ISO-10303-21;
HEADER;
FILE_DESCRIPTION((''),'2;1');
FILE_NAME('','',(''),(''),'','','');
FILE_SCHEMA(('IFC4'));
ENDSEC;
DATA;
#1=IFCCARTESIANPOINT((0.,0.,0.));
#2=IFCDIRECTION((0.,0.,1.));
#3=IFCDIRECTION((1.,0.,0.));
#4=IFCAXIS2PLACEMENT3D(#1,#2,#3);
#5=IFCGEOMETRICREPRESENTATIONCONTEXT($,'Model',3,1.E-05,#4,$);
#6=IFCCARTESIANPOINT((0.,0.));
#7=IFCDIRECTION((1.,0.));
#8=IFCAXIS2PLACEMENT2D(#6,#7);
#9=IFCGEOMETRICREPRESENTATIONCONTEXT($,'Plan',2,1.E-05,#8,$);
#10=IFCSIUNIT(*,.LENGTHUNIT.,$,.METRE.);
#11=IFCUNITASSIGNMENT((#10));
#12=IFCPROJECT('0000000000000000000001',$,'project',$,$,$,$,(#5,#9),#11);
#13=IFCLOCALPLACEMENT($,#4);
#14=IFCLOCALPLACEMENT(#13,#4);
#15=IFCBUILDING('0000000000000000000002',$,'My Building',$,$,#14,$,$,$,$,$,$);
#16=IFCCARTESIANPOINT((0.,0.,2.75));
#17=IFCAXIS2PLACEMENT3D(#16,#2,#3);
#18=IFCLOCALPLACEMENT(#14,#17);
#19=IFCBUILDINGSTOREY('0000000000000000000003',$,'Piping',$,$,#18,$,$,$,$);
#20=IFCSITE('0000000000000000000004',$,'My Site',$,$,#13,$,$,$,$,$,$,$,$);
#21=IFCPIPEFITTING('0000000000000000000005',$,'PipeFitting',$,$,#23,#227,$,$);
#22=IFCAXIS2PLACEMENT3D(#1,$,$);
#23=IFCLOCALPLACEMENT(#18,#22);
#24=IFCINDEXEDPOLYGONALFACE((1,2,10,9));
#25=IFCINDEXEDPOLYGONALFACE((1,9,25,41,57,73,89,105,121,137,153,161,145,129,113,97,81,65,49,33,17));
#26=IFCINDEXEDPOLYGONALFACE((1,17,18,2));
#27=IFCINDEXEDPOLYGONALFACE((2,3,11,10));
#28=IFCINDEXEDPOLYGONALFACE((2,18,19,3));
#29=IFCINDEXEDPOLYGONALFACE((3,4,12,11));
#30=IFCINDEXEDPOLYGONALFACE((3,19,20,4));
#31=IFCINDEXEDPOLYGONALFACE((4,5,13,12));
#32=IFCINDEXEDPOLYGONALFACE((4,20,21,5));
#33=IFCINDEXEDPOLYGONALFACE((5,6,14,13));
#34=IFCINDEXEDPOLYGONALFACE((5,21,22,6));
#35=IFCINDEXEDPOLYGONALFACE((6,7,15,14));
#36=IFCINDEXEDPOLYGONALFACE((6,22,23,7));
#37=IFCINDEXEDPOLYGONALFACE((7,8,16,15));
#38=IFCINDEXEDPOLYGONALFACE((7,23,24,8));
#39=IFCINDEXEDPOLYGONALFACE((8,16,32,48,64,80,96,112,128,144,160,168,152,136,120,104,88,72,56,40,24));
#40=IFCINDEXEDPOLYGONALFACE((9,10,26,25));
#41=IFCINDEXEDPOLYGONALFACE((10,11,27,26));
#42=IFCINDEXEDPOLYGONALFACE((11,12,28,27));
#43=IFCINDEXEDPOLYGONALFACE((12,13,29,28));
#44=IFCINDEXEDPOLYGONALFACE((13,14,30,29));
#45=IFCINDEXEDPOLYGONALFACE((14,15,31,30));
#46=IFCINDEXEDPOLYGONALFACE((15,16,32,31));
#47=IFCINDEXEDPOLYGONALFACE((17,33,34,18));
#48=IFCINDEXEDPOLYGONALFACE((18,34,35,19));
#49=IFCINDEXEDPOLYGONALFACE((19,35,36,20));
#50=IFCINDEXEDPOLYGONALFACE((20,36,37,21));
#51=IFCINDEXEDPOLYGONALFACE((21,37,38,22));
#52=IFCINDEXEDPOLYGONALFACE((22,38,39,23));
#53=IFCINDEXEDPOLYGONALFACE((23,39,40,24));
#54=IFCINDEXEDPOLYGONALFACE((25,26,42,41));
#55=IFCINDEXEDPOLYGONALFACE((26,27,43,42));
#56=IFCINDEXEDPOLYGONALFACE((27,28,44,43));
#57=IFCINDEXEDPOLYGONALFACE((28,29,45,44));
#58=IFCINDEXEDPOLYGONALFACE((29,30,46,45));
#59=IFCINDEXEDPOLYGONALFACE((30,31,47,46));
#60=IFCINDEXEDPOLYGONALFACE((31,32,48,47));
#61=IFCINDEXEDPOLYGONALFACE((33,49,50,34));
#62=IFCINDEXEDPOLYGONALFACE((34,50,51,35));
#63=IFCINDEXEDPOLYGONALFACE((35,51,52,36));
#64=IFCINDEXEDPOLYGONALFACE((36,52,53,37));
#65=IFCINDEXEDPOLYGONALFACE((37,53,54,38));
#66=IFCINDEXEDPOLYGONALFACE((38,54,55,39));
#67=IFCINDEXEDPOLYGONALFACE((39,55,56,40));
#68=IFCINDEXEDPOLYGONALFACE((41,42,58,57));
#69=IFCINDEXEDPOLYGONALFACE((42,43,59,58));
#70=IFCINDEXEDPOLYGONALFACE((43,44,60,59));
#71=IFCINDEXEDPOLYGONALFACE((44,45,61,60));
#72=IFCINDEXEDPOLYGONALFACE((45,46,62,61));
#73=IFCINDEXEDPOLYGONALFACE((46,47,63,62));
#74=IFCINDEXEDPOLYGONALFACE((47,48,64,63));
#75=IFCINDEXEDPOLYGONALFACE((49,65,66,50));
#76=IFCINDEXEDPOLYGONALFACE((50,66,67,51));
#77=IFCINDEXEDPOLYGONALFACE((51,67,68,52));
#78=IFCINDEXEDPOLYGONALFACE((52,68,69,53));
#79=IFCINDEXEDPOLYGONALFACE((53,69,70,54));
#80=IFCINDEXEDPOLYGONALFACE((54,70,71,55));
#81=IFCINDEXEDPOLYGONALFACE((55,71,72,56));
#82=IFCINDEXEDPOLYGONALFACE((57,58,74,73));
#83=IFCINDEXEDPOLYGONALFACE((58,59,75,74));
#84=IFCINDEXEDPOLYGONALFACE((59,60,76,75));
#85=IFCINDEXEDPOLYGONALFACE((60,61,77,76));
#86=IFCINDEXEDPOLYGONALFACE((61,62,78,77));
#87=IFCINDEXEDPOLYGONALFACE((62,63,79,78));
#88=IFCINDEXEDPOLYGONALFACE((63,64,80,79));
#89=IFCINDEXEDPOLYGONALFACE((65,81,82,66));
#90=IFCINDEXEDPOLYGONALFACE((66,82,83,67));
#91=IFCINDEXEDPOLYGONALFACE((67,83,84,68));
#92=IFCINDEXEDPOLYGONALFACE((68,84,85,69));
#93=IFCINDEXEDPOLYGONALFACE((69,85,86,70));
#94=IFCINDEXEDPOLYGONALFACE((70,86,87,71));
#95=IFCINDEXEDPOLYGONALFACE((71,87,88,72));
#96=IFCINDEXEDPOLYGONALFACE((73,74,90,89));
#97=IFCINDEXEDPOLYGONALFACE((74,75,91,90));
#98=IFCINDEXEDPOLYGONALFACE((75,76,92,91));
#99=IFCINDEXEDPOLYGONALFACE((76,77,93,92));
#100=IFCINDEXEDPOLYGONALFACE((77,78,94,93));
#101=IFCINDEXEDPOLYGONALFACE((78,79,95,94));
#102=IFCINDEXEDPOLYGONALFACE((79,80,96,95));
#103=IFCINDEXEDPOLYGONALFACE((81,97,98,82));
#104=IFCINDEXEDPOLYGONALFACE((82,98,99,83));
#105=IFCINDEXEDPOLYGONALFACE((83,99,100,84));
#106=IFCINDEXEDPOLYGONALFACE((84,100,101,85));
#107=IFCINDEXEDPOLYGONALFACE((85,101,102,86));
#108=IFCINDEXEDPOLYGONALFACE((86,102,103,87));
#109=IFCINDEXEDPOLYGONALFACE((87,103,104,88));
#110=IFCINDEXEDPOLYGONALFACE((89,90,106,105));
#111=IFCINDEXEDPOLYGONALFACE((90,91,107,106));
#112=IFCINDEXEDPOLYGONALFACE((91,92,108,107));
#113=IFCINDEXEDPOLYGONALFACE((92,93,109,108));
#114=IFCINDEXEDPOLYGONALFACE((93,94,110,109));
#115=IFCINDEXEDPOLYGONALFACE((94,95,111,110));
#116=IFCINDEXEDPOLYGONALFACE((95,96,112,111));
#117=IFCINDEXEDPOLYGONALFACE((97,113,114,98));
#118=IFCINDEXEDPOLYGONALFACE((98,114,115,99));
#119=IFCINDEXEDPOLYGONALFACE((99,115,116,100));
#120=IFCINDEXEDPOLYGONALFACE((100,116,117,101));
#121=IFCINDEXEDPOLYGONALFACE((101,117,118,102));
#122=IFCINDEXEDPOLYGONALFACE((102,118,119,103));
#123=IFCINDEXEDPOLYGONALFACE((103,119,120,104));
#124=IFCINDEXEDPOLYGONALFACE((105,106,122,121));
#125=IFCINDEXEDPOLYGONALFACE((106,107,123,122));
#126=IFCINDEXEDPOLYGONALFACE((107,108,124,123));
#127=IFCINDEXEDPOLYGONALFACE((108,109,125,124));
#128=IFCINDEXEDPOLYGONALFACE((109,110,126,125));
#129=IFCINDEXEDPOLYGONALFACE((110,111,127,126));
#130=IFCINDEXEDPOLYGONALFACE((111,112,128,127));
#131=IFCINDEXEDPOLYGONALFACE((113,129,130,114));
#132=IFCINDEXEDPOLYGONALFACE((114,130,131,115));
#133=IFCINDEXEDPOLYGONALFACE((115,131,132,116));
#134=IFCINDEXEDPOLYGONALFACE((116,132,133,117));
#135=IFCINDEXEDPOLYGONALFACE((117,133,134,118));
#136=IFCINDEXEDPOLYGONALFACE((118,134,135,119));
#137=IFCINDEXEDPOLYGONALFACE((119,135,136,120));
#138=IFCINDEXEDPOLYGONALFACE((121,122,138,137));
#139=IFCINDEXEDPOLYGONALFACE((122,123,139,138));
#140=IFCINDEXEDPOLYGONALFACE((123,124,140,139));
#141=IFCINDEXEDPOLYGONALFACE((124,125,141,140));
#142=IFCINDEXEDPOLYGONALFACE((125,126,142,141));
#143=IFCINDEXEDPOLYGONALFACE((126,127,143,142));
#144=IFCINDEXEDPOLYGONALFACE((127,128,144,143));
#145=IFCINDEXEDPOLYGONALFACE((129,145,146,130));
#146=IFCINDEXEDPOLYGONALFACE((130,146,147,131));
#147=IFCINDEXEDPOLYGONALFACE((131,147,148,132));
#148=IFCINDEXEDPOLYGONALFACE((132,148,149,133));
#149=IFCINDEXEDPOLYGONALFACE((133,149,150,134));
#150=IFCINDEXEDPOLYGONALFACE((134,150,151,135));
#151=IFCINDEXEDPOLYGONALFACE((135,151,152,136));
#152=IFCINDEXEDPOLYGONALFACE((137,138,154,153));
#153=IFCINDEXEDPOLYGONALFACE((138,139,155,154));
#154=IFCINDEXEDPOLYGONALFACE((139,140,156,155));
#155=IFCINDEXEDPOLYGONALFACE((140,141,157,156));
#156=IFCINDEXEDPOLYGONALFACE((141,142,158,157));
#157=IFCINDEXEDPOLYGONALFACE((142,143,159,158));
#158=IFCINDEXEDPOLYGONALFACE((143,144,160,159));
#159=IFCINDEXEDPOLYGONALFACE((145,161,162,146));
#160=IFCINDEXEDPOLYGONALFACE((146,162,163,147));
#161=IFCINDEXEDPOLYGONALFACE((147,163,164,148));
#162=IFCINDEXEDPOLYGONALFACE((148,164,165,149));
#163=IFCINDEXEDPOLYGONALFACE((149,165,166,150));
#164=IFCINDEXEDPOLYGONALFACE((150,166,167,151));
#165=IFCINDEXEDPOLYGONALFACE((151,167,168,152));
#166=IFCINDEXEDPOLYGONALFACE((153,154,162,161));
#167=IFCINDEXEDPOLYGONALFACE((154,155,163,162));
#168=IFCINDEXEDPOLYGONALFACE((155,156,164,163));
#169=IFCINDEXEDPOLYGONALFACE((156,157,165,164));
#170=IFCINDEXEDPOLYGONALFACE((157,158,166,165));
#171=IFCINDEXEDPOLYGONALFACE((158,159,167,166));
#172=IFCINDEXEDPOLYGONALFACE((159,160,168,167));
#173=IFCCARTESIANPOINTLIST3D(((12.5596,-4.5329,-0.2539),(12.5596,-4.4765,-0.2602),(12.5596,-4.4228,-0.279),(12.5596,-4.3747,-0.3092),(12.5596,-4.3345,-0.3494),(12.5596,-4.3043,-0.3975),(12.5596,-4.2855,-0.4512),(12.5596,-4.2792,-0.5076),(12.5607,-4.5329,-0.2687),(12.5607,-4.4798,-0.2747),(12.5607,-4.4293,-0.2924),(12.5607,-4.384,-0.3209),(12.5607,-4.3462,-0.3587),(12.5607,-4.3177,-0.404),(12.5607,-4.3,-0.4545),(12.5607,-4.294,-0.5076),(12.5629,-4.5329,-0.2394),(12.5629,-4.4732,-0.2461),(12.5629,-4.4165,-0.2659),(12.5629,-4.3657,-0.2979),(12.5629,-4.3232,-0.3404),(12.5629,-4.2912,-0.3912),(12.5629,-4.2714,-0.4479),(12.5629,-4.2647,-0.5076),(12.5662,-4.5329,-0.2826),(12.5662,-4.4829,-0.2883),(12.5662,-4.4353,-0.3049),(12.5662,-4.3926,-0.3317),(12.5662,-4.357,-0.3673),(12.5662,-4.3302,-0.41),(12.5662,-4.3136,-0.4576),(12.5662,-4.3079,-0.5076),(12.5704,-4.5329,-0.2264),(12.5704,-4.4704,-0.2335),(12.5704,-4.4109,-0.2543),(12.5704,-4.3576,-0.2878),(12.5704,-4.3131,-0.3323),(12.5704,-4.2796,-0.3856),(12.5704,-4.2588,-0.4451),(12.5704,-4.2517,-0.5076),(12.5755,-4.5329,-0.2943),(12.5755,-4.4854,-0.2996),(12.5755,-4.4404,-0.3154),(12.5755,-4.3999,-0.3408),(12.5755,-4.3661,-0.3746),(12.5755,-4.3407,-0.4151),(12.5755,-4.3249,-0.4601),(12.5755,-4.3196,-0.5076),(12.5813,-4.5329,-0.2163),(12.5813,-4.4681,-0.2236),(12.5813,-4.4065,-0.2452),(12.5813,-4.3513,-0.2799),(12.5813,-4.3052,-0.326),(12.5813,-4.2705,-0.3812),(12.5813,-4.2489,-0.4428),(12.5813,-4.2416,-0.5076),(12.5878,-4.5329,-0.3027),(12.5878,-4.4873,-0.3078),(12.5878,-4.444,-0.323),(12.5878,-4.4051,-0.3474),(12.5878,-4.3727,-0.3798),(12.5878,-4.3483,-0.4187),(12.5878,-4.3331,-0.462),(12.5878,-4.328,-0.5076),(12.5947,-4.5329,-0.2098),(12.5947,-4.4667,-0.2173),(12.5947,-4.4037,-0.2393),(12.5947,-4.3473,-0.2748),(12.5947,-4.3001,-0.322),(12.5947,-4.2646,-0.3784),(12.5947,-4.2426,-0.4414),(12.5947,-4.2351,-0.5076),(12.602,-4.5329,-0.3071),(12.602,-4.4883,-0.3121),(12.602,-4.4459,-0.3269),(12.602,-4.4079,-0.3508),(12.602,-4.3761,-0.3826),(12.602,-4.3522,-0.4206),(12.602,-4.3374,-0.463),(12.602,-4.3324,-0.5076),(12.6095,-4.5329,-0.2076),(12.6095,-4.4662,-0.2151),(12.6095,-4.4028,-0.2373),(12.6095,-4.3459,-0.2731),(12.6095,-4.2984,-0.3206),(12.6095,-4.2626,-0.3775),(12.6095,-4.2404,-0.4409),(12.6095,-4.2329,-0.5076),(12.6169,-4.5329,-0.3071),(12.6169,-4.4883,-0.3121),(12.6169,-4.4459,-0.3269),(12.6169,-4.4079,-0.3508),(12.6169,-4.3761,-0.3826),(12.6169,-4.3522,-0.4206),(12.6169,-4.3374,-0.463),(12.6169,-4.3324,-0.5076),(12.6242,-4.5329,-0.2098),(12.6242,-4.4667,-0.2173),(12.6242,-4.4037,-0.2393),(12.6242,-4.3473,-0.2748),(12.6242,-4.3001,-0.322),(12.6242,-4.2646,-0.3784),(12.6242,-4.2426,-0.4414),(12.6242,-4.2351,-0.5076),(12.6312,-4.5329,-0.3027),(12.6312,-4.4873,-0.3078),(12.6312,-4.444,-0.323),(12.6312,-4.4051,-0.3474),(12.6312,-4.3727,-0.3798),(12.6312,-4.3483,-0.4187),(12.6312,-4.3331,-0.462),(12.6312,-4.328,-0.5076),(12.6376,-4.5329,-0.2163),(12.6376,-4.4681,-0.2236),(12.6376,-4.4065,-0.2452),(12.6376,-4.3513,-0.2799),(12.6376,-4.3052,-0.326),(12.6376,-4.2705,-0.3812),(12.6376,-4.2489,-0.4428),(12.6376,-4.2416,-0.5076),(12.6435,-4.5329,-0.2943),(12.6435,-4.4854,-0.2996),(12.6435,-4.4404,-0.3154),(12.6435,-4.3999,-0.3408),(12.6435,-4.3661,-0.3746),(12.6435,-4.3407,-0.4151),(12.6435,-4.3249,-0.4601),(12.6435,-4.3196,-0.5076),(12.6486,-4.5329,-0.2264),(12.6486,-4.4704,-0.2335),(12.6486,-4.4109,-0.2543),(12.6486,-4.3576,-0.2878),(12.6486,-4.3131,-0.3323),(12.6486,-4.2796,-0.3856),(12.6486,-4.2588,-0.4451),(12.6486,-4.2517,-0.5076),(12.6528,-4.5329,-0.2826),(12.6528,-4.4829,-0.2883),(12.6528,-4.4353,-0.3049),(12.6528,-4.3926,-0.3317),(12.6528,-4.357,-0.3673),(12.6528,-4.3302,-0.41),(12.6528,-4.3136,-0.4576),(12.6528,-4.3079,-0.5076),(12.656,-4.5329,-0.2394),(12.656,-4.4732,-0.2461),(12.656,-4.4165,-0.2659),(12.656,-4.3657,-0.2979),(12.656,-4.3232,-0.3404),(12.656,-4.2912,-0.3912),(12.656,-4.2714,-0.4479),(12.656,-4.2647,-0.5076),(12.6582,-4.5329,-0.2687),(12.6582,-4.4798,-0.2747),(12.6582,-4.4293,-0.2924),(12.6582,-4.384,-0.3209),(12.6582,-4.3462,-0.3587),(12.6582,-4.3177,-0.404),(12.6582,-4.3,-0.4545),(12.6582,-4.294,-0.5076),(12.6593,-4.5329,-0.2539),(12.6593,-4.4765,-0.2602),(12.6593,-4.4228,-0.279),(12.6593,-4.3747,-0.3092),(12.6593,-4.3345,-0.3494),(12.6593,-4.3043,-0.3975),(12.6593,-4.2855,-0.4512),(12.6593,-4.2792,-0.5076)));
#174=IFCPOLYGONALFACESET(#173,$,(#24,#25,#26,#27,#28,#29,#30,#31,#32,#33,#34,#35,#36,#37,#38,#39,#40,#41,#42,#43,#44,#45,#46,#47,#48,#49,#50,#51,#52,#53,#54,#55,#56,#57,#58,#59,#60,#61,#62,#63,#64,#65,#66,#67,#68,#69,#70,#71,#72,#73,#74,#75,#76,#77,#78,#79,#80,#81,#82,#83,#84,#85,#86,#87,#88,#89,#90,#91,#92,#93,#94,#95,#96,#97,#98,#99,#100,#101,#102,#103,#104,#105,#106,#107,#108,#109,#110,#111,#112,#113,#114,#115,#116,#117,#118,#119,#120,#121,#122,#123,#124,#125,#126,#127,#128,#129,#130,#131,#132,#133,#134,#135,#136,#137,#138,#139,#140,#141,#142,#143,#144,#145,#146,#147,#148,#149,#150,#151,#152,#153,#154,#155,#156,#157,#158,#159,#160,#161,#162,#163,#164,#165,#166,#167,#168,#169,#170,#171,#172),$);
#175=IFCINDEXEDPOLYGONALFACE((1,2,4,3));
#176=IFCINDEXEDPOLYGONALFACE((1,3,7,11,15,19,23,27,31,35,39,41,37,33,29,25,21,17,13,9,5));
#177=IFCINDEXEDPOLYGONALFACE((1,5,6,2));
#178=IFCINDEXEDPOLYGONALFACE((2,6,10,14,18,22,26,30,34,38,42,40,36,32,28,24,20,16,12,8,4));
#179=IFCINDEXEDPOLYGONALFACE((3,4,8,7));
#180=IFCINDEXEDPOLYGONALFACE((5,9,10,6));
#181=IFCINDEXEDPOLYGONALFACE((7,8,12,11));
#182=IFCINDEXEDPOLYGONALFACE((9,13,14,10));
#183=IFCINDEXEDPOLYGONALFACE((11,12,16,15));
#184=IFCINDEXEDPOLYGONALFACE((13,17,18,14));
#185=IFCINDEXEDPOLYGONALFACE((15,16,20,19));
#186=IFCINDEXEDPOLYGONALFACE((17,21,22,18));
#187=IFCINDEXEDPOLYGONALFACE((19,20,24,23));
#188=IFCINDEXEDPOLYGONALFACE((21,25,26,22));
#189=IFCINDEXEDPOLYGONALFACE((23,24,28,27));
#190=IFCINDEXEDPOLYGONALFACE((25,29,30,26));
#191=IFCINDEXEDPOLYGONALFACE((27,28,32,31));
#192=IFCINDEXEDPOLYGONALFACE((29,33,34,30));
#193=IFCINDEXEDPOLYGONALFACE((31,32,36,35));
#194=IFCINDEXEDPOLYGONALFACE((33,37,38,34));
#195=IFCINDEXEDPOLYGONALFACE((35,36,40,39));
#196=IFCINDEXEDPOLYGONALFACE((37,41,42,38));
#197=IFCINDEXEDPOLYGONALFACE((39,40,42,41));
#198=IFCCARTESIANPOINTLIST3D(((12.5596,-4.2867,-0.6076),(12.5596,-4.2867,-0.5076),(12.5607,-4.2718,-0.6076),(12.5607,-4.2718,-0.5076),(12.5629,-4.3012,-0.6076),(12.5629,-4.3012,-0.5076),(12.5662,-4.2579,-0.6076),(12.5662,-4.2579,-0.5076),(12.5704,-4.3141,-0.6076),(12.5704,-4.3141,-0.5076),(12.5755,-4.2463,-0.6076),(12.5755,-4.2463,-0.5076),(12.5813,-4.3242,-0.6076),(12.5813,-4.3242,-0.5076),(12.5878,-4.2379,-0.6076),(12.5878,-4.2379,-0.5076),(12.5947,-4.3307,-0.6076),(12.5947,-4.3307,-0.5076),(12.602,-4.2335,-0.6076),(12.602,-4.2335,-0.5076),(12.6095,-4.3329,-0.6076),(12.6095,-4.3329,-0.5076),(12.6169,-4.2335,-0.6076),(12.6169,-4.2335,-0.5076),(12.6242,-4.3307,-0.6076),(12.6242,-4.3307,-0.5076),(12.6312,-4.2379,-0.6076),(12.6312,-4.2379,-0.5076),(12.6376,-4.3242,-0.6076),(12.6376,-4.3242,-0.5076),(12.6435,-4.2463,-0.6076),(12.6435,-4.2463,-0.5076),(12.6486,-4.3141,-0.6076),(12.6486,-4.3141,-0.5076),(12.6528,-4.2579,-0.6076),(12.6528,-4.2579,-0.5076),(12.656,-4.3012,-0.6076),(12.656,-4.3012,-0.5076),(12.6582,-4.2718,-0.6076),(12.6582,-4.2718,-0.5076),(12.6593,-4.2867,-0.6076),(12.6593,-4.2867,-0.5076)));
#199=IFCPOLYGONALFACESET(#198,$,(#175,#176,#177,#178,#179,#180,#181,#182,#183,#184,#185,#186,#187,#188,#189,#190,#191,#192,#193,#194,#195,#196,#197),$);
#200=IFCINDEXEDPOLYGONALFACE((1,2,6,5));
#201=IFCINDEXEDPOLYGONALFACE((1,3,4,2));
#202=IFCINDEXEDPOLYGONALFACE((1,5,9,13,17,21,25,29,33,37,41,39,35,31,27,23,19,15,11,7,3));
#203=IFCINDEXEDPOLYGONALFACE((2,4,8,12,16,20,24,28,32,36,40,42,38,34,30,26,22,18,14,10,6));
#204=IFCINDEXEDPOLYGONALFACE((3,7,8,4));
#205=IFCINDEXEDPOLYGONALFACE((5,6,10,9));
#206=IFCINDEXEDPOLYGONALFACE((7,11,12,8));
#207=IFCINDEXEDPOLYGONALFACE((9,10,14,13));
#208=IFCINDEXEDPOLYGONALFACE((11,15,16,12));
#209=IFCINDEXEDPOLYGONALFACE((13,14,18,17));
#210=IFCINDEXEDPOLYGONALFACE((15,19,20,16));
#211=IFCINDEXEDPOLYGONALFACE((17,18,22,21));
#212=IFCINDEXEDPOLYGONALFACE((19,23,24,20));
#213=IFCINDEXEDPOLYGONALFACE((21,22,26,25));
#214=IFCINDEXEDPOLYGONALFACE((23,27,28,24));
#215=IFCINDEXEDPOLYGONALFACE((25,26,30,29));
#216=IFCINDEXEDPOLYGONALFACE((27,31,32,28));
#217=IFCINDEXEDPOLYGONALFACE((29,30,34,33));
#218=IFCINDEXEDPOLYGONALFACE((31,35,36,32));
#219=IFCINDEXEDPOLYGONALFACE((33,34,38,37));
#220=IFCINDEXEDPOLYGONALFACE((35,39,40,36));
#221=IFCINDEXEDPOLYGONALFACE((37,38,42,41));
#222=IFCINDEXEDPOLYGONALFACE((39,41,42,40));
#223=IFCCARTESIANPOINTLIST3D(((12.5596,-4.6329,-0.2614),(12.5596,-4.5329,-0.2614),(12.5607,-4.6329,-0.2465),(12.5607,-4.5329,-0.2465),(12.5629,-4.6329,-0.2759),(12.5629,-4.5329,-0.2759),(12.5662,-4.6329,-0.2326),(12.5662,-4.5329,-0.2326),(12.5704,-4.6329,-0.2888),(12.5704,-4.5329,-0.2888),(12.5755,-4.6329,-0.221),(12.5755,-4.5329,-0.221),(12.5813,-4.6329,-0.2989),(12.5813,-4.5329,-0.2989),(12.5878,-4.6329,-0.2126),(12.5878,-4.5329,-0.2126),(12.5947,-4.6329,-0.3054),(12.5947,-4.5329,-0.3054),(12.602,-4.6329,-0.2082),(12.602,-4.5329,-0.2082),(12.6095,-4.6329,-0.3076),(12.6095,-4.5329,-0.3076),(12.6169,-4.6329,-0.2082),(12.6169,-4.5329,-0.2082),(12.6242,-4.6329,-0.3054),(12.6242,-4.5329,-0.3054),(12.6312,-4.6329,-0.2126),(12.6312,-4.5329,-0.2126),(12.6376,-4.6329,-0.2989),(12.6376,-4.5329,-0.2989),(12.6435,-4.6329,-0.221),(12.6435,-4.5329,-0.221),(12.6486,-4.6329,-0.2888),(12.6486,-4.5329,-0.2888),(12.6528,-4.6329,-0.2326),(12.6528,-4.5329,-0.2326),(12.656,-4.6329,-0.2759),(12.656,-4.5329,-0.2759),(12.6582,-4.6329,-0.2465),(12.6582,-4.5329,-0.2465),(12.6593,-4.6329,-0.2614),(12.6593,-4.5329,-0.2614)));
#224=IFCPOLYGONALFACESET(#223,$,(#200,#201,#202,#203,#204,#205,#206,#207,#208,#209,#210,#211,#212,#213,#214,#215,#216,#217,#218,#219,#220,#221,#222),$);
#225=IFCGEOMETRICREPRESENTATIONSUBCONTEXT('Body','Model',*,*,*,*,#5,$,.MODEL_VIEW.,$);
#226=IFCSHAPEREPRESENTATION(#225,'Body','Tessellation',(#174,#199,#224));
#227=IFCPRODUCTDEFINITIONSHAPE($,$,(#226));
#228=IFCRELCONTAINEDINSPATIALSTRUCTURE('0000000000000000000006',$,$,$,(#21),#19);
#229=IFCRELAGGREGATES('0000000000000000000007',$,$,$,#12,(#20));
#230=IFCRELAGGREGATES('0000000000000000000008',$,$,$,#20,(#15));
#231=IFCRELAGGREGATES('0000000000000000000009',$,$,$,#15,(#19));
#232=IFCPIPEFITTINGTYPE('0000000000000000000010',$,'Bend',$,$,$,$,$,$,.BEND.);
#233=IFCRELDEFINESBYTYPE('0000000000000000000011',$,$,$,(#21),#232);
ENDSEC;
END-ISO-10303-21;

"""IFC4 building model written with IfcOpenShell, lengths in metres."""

from ifc_helpers import new_model, entity, si_unit, frame, origin_with_axes, origin_2d_with_axis, place, context, subcontext, project, spatial, circle, extrude, source, transform, mapped, type_object, type_shapes, element, save


model = new_model("IFC4")

# Units and contexts
model_context = context("Model", 3, precision=1e-05, world=origin_with_axes())
plan_context = context("Plan", 2, precision=1e-05, world=origin_2d_with_axis())
body_context = subcontext(model_context, "Body", "Model", "MODEL_VIEW")
ifc_project = project(units=[si_unit("LENGTHUNIT", "METRE")], contexts=[model_context, plan_context])

# Site, building, storey
site_placement = place(None, origin_with_axes())
site = spatial("IfcSite", under=ifc_project, at=site_placement, Name="My Site")
building_placement = place(site_placement, origin_with_axes())
building = spatial("IfcBuilding", under=site, at=building_placement, Name="My Building")
storey_placement = place(building_placement, frame((0.0, 0.0, 2.75), z_axis=(0.0, 0.0, 1.0), x_axis=(1.0, 0.0, 0.0)))
storey = spatial("IfcBuildingStorey", under=building, at=storey_placement, Name="Piping")

# Pipe fitting
pipe_fitting_type = type_object("IfcPipeFittingType", Name="Bend", PredefinedType="BEND")
shared_shape = source(origin_with_axes(), body_context, "Body", "SolidModel", [
    entity("IfcSweptDiskSolid", entity("IfcIndexedPolyCurve", entity("IfcCartesianPointList3D", [[0.0, 0.0, -0.1], [0.0732, 0.0, -0.2768], [0.25, 0.0, -0.35]]), [entity("IfcArcIndex", [1, 2, 3])]), 0.05),
    extrude(circle(Radius=0.05), origin_with_axes(), (0.0, 0.0, -1.0), 0.1),
    extrude(circle(Radius=0.05), frame((0.25, 0.0, -0.35), z_axis=(1.0, 0.0, 0.0), x_axis=(0.0, 0.0, 1.0)), (0.0, 0.0, 1.0), 0.1),
])
type_shapes(pipe_fitting_type, [shared_shape])
for number, where, z_axis, x_axis, name in (
    (1, (12.6095, -4.2829, -0.6076), (0.0, 0.0, -1.0), (0.0, -1.0, 0.0), "PipeFitting"),
):
    element("IfcPipeFitting", number, at=place(storey_placement, frame(where, z_axis=z_axis, x_axis=x_axis)), inside=storey, type_object=pipe_fitting_type, Name=name, context=body_context, shape_type="MappedRepresentation", body=[
        mapped(shared_shape, transform((0.0, 0.0, 0.0), x_axis=(1.0, 0.0, 0.0), y_axis=(0.0, 1.0, 0.0), z_axis=(0.0, 0.0, 1.0), scale=1.0)),
    ])

save(model, "model.ifc")
